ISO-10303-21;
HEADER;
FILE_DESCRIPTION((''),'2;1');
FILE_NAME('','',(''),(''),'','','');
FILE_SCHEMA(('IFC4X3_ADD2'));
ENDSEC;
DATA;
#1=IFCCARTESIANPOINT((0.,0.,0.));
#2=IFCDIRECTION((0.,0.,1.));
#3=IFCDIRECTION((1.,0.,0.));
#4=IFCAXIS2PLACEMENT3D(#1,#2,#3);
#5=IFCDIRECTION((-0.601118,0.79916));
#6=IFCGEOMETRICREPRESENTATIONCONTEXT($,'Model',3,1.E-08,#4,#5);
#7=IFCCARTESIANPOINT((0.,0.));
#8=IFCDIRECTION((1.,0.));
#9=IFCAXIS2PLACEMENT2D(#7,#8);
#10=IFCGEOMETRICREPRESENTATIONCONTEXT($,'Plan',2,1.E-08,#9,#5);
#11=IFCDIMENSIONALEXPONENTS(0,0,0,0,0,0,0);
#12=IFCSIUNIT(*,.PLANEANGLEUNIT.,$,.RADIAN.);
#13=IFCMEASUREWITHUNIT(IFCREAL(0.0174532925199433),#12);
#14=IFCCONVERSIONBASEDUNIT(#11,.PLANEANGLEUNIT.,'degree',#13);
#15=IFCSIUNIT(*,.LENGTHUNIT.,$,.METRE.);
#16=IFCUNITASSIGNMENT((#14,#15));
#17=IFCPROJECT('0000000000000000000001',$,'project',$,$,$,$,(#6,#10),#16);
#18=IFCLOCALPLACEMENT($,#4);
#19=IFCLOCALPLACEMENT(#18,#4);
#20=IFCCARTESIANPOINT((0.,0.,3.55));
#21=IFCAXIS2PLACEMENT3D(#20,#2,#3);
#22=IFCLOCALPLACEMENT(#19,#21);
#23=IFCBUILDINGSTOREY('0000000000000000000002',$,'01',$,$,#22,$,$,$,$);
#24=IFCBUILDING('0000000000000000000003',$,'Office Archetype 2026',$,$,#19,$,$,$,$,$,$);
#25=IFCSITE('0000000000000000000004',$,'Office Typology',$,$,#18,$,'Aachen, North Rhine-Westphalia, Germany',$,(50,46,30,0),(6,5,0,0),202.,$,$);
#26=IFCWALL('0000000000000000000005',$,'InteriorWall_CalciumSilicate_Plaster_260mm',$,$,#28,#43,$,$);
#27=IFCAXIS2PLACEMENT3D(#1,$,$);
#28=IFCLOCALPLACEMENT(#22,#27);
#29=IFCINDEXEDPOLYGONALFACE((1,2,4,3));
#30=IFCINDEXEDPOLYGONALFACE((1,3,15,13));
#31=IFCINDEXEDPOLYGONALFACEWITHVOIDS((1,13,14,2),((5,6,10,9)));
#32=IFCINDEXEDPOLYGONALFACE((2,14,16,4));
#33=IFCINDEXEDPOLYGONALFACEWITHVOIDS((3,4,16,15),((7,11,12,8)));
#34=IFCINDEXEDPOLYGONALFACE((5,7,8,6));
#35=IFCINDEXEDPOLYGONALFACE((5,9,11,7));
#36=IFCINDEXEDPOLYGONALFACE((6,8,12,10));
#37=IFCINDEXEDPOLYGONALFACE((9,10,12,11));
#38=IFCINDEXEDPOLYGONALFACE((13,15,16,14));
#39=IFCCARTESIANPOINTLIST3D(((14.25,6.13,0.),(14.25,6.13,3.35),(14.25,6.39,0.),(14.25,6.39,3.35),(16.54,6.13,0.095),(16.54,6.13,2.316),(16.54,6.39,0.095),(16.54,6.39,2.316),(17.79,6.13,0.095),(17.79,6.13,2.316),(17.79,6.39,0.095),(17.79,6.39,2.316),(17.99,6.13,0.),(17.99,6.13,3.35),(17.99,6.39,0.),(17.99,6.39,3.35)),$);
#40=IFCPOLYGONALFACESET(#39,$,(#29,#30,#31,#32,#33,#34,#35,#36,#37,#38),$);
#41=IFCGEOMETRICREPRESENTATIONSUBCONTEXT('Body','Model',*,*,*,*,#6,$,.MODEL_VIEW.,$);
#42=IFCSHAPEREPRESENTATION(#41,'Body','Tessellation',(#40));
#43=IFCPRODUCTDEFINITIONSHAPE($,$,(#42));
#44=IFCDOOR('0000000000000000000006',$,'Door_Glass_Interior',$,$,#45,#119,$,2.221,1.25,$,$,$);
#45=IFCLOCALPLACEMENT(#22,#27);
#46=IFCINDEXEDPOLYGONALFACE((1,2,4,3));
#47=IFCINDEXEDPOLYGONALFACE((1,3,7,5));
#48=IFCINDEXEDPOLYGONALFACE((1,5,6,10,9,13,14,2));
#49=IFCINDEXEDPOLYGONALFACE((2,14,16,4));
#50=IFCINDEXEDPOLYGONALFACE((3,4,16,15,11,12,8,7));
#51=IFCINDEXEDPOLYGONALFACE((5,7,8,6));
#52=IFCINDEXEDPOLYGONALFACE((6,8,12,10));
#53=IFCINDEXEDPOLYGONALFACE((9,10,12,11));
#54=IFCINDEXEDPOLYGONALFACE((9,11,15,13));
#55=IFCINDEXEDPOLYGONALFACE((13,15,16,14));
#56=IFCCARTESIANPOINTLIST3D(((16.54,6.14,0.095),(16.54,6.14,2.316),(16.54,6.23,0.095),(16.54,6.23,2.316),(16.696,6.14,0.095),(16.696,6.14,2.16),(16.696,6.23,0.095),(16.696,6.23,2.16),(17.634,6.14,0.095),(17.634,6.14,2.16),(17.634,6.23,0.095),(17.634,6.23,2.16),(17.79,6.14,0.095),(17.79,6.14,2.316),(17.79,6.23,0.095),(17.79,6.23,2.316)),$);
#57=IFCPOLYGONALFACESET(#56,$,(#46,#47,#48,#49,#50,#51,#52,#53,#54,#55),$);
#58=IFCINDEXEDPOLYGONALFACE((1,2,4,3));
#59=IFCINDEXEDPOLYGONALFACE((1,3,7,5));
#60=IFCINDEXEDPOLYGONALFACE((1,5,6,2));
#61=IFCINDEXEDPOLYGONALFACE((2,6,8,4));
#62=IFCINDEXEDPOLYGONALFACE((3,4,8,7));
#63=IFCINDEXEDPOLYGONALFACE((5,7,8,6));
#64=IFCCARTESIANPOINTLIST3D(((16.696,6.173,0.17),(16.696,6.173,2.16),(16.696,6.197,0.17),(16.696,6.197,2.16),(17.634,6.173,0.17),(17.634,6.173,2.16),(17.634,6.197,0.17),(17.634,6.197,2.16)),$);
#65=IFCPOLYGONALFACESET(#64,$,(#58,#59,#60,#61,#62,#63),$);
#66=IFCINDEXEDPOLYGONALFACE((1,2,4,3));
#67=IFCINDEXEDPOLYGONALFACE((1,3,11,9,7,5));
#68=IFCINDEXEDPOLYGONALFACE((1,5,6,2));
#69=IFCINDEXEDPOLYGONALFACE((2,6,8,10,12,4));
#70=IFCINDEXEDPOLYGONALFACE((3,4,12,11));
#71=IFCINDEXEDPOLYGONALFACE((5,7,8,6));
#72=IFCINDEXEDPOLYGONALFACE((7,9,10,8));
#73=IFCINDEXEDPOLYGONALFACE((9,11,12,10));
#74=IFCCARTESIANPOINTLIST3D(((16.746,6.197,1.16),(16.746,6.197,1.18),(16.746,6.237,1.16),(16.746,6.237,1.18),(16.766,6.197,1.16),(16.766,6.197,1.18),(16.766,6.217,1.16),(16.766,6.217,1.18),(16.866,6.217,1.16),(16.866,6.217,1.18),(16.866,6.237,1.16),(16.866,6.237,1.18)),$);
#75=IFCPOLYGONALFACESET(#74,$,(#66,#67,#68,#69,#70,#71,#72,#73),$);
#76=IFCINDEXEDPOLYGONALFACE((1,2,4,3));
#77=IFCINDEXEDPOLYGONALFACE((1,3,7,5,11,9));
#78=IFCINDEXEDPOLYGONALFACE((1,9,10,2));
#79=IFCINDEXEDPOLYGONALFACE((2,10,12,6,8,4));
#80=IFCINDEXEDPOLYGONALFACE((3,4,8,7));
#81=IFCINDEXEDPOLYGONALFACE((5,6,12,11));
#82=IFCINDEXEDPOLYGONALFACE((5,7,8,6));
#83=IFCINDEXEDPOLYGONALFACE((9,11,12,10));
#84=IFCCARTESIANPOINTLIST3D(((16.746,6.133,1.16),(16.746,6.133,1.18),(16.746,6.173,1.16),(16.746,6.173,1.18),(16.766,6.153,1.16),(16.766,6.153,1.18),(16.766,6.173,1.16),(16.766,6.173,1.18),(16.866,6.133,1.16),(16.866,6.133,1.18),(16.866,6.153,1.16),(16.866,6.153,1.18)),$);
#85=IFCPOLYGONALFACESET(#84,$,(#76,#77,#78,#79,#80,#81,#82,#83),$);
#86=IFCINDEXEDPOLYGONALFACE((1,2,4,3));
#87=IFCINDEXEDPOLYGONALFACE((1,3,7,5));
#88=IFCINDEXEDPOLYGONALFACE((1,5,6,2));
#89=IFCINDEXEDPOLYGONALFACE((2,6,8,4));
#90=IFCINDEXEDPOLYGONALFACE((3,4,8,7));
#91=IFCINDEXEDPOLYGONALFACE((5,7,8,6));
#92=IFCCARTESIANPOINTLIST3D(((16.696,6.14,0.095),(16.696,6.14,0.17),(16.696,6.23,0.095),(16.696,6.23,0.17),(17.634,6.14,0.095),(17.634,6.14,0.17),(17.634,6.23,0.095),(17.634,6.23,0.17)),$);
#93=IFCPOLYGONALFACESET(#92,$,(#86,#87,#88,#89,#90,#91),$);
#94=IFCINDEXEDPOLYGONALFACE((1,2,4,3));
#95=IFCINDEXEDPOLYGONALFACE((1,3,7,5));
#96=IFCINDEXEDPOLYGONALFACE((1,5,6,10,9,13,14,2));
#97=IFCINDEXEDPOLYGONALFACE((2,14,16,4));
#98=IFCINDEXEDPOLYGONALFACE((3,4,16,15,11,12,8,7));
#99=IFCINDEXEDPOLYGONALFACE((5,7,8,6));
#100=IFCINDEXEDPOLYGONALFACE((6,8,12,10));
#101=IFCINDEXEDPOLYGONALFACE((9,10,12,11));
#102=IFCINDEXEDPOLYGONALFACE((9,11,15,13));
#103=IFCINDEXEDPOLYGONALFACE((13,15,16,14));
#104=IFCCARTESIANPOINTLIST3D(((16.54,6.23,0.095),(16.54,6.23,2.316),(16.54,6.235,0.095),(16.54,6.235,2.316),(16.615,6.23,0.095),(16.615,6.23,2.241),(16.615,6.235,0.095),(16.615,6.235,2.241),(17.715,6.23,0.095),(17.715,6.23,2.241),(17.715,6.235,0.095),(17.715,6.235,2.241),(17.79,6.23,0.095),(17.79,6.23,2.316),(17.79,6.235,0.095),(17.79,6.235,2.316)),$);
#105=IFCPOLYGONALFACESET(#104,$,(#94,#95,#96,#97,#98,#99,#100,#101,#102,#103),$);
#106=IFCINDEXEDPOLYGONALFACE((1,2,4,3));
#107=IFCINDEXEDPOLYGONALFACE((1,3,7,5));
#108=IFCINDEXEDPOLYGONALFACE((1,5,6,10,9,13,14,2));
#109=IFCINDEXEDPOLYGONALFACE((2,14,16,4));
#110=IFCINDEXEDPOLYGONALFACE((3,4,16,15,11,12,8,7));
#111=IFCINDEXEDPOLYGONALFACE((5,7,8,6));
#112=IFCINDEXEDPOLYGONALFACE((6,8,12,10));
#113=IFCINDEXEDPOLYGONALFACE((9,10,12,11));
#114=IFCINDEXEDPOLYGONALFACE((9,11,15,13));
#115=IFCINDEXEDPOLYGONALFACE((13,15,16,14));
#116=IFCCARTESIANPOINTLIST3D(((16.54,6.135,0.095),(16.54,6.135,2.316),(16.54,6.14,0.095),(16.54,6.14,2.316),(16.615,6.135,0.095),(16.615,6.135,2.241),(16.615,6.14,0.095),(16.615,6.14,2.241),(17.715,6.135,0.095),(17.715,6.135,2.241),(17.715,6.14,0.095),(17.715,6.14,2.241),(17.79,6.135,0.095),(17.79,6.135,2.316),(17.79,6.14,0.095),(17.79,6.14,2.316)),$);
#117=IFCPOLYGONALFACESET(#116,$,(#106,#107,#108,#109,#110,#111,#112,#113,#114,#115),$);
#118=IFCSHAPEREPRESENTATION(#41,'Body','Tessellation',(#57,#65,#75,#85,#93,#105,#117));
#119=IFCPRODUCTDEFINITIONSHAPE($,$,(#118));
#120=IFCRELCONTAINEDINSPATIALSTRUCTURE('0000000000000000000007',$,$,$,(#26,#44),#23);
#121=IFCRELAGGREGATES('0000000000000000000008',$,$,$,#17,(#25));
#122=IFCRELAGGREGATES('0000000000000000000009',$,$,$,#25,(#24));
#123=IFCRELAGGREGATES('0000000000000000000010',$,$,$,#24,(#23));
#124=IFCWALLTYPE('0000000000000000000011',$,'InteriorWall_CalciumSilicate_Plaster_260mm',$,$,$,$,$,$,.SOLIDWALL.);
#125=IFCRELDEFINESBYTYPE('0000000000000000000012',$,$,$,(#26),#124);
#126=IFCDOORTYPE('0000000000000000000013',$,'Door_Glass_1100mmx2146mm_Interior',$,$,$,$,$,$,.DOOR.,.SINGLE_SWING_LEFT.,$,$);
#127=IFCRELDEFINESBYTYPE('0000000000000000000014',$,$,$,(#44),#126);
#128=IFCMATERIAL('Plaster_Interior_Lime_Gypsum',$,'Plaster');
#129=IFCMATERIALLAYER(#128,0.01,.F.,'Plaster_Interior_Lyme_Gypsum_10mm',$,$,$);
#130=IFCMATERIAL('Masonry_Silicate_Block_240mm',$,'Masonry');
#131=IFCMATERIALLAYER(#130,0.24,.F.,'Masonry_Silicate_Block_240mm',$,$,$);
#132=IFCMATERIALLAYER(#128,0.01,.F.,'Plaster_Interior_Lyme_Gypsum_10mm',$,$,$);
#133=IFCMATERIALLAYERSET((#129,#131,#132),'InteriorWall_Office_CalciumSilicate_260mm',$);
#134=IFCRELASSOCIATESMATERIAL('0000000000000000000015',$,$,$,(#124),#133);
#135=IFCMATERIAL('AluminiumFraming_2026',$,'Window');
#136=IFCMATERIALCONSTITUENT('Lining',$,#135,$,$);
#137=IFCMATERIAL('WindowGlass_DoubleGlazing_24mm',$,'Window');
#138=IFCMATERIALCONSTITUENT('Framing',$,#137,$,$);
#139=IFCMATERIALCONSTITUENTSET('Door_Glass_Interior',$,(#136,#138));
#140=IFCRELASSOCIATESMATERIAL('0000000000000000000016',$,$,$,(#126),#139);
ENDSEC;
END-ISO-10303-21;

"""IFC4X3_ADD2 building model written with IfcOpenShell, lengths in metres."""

from ifc_helpers import new_model, entity, si_unit, converted_unit, direction, frame, origin_with_axes, origin_2d_with_axis, place, context, subcontext, project, spatial, line, indexed_curve, outline, extrude, source, transform, mapped, material, layer, layer_set, constituent, constituent_set, type_object, type_shapes, element, fill, save


model = new_model("IFC4X3_ADD2")

# Units and contexts
model_context = context("Model", 3, precision=1e-08, world=origin_with_axes(), true_north=direction((-0.601118, 0.79916)))
plan_context = context("Plan", 2, precision=1e-08, world=origin_2d_with_axis(), true_north=direction((-0.601118, 0.79916)))
body_context = subcontext(model_context, "Body", "Model", "MODEL_VIEW")
ifc_project = project(units=[converted_unit("PLANEANGLEUNIT", "degree", entity("IfcReal", 0.0174532925199433), si_unit("PLANEANGLEUNIT", "RADIAN"), dimensions=[0, 0, 0, 0, 0, 0, 0]), si_unit("LENGTHUNIT", "METRE")], contexts=[model_context, plan_context])

# Site, building, storey
site_placement = place(None, origin_with_axes())
site = spatial("IfcSite", under=ifc_project, at=site_placement, Name="Office Typology", LongName="Aachen, North Rhine-Westphalia, Germany", RefLatitude=(50, 46, 30, 0), RefLongitude=(6, 5, 0, 0), RefElevation=202.0)
building_placement = place(site_placement, origin_with_axes())
building = spatial("IfcBuilding", under=site, at=building_placement, Name="Office Archetype 2026")
storey_placement = place(building_placement, frame((0.0, 0.0, 3.55), z_axis=(0.0, 0.0, 1.0), x_axis=(1.0, 0.0, 0.0)))
storey = spatial("IfcBuildingStorey", under=building, at=storey_placement, Name="01")

# Shared definitions
ifc_material_1 = material(Name="Plaster_Interior_Lime_Gypsum", Category="Plaster")
ifc_layer_1 = layer(ifc_material_1, 0.01, ventilated=False, Name="Plaster_Interior_Lyme_Gypsum_10mm")
ifc_material_2 = material(Name="Masonry_Silicate_Block_240mm", Category="Masonry")
ifc_layer_2 = layer(ifc_material_2, 0.24, ventilated=False, Name="Masonry_Silicate_Block_240mm")
ifc_layer_3 = layer(ifc_material_1, 0.01, ventilated=False, Name="Plaster_Interior_Lyme_Gypsum_10mm")
ifc_layer_set = layer_set([ifc_layer_1, ifc_layer_2, ifc_layer_3], Name="InteriorWall_Office_CalciumSilicate_260mm")
wall_type = type_object("IfcWallType", Name="InteriorWall_CalciumSilicate_Plaster_260mm", PredefinedType="SOLIDWALL", material=ifc_layer_set)

# Wall, opening, door
wall_1_placement = place(storey_placement, frame((18.25, 6.39, 0.0), z_axis=(0.0, 0.0, 1.0), x_axis=(-1.0, 0.0, 0.0)))
wall_1 = element("IfcWall", 1, at=wall_1_placement, inside=storey, type_object=wall_type, Name="InteriorWall_CalciumSilicate_Plaster_260mm", context=body_context, shape_type="SweptSolid", body=[
    extrude(outline(indexed_curve([(0.26, 0.0), (0.26, 0.26), (4.0, 0.26), (4.0, 0.0)], segments=[line(1, 2, 3, 4, 1)])), origin_with_axes(), (0.0, 0.0, 1.0), 3.35),
])
shared_shape_1 = source(origin_with_axes(), body_context, "Body", "SweptSolid", [
    extrude(outline(indexed_curve([(0.0, 2.221), (1.25, 2.221), (1.25, 0.0), (0.0, 0.0), (0.0, 2.221)])), frame((0.0, -0.16, 0.0), z_axis=(0.0, -1.0, 0.0), x_axis=(1.0, 0.0, 0.0)), (0.0, 0.0, -1.0), 0.26),
])
opening_1_placement = place(wall_1_placement, frame((0.46, 0.16, 0.095), z_axis=(0.0, 0.0, 1.0), x_axis=(1.0, 0.0, 0.0)))
opening_1 = element("IfcOpeningElement", 2, at=opening_1_placement, cuts=wall_1, PredefinedType="OPENING", context=body_context, shape_type="MappedRepresentation", body=[
    mapped(shared_shape_1, transform((0.0, 0.0, 0.0), x_axis=(1.0, 0.0, 0.0), y_axis=(0.0, 1.0, 0.0), z_axis=(0.0, 0.0, 1.0), scale=1.0)),
])
ifc_material_3 = material(Name="AluminiumFraming_2026", Category="Window")
ifc_constituent_1 = constituent(ifc_material_3, Name="Lining")
ifc_material_4 = material(Name="WindowGlass_DoubleGlazing_24mm", Category="Window")
ifc_constituent_2 = constituent(ifc_material_4, Name="Framing")
ifc_constituent_set_1 = constituent_set(constituents=[ifc_constituent_1, ifc_constituent_2], Name="Door_Glass_Interior")
door_type_1 = type_object("IfcDoorType", Name="Door_Glass_1100mmx2146mm_Interior", OperationType="SINGLE_SWING_LEFT", PredefinedType="DOOR", material=ifc_constituent_set_1)
shared_shape_2 = source(origin_with_axes(), body_context, "Body", "SweptSolid", [
    extrude(outline(indexed_curve([(0.0, 0.0), (0.0, 2.221), (1.25, 2.221), (1.25, 0.0), (1.094, 0.0), (1.094, 2.065), (0.156, 2.065), (0.156, 0.0)], segments=[line(1, 2, 3, 4, 5, 6, 7, 8, 1)])), frame((0.0, 0.0, 0.0), z_axis=(0.0, -1.0, 0.0), x_axis=(1.0, 0.0, 0.0)), (0.0, 0.0, -1.0), 0.09),
    extrude(outline(indexed_curve([(0.0, 0.0), (0.938, 0.0), (0.938, 0.024), (0.0, 0.024)], segments=[line(1, 2, 3, 4, 1)])), frame((0.156, 0.033, 0.075), z_axis=(0.0, 0.0, 1.0), x_axis=(1.0, 0.0, 0.0)), (0.0, 0.0, 1.0), 1.99),
    extrude(outline(indexed_curve([(0.0, 0.0), (0.0, -0.04), (-0.12, -0.04), (-0.12, -0.02), (-0.02, -0.02), (-0.02, 0.0)], segments=[line(1, 2, 3, 4, 5, 6, 1)])), frame((1.044, 0.033, 1.065), z_axis=(0.0, 0.0, 1.0), x_axis=(1.0, 0.0, 0.0)), (0.0, 0.0, 1.0), 0.02),
    extrude(outline(indexed_curve([(0.0, 0.0), (0.0, 0.04), (-0.12, 0.04), (-0.12, 0.02), (-0.02, 0.02), (-0.02, 0.0)], segments=[line(1, 2, 3, 4, 5, 6, 1)])), frame((1.044, 0.057, 1.065), z_axis=(0.0, 0.0, 1.0), x_axis=(1.0, 0.0, 0.0)), (0.0, 0.0, 1.0), 0.02),
    extrude(outline(indexed_curve([(0.0, 0.0), (0.938, 0.0), (0.938, 0.09), (0.0, 0.09)], segments=[line(1, 2, 3, 4, 1)])), frame((0.156, 0.0, 0.0), z_axis=(0.0, 0.0, 1.0), x_axis=(1.0, 0.0, 0.0)), (0.0, 0.0, 1.0), 0.075),
    extrude(outline(indexed_curve([(0.0, 0.0), (0.0, 2.221), (1.25, 2.221), (1.25, 0.0), (1.175, 0.0), (1.175, 2.146), (0.075, 2.146), (0.075, 0.0)], segments=[line(1, 2, 3, 4, 5, 6, 7, 8, 1)])), frame((0.0, -0.005, 0.0), z_axis=(0.0, -1.0, 0.0), x_axis=(1.0, 0.0, 0.0)), (0.0, 0.0, -1.0), 0.005),
    extrude(outline(indexed_curve([(0.0, 0.0), (0.0, 2.221), (1.25, 2.221), (1.25, 0.0), (1.175, 0.0), (1.175, 2.146), (0.075, 2.146), (0.075, 0.0)], segments=[line(1, 2, 3, 4, 5, 6, 7, 8, 1)])), frame((0.0, 0.09, 0.0), z_axis=(0.0, -1.0, 0.0), x_axis=(1.0, 0.0, 0.0)), (0.0, 0.0, -1.0), 0.005),
])
type_shapes(door_type_1, [shared_shape_2])
door_1_placement = place(opening_1_placement, origin_with_axes())
door_1 = element("IfcDoor", 3, at=door_1_placement, inside=storey, type_object=door_type_1, Name="Door_Glass_Interior", OverallHeight=2.221, OverallWidth=1.25, context=body_context, shape_type="MappedRepresentation", body=[
    mapped(shared_shape_2, transform((0.0, 0.0, 0.0), x_axis=(1.0, 0.0, 0.0), y_axis=(0.0, 1.0, 0.0), z_axis=(0.0, 0.0, 1.0), scale=1.0)),
])
fill(opening_1, door_1)

save(model, "model.ifc")
